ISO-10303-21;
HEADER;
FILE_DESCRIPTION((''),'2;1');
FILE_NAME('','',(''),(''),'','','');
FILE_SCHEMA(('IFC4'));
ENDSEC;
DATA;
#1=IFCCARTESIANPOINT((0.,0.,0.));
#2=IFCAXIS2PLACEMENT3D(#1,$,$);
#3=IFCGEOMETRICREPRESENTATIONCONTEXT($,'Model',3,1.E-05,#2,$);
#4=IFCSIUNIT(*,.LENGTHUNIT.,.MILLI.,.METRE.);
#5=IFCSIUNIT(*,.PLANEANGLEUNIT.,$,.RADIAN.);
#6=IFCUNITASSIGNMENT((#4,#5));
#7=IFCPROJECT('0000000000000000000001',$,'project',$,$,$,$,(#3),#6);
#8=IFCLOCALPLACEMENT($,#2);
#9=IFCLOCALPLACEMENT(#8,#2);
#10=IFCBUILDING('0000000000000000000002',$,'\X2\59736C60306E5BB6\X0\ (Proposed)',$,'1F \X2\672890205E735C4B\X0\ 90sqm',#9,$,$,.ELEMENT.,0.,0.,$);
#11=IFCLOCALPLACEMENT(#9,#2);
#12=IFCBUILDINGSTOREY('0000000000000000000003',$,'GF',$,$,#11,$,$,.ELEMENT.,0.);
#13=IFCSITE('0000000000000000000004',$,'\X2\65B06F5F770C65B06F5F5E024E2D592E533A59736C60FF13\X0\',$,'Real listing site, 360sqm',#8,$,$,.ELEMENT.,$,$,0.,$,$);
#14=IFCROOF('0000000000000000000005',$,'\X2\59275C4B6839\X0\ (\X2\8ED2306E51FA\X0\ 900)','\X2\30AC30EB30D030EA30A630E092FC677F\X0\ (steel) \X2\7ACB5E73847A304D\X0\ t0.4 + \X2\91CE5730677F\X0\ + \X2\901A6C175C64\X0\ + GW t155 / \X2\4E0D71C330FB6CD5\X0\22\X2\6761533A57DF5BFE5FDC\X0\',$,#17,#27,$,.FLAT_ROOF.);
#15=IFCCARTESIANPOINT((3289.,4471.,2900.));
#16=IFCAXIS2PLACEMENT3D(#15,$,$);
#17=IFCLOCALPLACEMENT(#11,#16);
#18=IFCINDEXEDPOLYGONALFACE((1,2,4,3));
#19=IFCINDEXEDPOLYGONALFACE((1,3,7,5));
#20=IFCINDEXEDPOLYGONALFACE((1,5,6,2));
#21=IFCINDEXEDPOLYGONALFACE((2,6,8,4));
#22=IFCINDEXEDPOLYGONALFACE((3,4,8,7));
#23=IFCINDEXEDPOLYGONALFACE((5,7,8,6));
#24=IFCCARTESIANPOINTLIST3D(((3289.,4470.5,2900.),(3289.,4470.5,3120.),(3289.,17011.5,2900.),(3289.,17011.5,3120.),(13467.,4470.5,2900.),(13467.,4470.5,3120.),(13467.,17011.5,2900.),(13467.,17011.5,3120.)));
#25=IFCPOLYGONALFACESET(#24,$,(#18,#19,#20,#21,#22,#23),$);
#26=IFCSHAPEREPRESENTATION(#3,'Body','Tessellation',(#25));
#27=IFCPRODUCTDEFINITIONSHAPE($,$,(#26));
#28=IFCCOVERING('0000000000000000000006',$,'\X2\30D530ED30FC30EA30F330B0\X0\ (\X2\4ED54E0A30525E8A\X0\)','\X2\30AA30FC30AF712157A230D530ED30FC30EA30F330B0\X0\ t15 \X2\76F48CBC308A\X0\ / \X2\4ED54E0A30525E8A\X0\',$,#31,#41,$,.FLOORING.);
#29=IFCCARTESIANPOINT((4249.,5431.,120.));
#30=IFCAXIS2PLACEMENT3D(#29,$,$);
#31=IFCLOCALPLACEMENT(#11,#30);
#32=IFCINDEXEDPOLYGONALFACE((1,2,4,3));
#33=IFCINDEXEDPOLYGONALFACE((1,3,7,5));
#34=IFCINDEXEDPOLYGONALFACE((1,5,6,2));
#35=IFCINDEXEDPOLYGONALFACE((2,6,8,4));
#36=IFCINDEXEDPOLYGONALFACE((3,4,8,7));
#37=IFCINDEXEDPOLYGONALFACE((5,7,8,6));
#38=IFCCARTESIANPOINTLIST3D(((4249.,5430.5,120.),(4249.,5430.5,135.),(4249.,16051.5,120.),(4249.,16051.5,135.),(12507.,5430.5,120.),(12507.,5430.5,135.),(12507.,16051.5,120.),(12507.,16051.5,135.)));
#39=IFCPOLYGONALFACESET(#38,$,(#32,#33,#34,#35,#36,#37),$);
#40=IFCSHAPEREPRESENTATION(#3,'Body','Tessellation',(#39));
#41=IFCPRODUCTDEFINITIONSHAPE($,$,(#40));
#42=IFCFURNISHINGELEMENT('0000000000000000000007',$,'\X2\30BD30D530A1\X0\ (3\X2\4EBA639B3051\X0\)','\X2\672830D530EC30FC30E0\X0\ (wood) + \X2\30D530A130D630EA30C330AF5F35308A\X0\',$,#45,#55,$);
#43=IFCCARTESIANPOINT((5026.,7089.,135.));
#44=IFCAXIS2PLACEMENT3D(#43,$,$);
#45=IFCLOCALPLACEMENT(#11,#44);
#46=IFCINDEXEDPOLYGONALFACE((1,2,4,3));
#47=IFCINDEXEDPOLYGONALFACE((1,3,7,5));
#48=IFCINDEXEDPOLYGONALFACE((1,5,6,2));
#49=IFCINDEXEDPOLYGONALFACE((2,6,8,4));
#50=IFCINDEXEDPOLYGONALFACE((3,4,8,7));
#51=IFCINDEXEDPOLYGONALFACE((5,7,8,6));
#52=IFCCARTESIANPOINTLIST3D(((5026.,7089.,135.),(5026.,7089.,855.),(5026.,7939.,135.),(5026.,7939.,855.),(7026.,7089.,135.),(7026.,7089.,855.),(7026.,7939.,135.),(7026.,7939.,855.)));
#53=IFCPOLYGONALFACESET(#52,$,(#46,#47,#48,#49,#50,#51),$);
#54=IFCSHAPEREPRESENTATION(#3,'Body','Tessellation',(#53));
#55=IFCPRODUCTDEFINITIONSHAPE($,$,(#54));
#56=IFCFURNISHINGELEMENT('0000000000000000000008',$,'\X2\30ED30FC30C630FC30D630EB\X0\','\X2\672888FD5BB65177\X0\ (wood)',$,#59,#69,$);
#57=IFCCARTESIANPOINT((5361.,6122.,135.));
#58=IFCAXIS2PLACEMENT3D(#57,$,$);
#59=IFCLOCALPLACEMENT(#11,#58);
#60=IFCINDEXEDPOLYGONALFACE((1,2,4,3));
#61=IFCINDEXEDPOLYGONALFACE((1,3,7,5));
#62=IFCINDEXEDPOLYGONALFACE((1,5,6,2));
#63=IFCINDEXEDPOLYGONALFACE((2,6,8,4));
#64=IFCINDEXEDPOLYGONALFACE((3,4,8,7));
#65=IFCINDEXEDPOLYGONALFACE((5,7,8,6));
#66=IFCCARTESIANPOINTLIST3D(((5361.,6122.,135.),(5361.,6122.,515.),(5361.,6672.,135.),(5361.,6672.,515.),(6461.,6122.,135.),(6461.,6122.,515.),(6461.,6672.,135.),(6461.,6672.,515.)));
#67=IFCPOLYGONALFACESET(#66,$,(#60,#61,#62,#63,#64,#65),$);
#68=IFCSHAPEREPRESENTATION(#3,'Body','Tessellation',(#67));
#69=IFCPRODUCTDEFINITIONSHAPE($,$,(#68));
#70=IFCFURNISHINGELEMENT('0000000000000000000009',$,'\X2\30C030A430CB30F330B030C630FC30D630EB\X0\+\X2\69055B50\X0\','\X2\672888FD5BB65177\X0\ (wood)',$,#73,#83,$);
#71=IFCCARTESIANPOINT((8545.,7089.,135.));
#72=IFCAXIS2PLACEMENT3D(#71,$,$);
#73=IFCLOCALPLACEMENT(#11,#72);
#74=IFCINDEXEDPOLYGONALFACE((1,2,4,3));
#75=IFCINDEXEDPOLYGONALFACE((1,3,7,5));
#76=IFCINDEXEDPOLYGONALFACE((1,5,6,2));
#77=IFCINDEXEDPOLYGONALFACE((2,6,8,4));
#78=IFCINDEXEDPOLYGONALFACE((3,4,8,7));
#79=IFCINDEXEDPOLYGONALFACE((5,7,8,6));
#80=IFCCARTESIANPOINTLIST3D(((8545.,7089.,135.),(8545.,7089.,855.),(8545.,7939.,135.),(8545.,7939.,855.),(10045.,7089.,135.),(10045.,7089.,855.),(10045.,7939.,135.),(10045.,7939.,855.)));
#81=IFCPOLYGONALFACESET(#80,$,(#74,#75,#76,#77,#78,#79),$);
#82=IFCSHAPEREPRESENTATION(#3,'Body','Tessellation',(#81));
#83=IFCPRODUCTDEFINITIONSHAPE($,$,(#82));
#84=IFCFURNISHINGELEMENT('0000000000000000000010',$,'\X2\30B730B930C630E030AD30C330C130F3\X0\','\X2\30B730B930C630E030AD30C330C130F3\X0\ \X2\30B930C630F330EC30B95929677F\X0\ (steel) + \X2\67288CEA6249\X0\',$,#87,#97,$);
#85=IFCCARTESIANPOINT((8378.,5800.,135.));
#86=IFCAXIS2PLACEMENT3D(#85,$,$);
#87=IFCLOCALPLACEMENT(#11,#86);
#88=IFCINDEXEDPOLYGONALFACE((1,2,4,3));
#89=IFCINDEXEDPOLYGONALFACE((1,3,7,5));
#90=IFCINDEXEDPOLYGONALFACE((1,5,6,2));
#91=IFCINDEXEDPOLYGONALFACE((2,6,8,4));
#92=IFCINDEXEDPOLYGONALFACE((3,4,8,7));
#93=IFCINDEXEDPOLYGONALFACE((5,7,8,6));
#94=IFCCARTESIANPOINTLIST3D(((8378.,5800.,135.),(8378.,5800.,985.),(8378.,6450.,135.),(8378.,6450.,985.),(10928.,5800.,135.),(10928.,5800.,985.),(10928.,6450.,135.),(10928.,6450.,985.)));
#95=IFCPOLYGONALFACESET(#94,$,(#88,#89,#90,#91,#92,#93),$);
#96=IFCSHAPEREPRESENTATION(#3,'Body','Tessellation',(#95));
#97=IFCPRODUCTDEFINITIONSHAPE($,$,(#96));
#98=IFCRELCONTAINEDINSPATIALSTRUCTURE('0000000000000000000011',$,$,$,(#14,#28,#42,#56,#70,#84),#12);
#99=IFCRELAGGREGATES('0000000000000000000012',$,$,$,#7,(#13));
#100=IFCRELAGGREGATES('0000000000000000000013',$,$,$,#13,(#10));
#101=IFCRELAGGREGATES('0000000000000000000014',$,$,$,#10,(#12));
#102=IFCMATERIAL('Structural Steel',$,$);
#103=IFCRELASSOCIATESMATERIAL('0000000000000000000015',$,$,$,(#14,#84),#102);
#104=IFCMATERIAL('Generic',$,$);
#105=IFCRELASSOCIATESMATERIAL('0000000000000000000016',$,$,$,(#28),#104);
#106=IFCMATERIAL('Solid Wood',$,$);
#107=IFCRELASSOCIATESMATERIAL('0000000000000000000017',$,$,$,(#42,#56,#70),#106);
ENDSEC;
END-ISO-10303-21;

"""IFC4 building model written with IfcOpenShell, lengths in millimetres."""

from ifc_helpers import new_model, si_unit, frame, frame_2d, origin, place, context, project, spatial, rectangle, extrude, material, element, save


model = new_model("IFC4")

# Units and contexts
model_context = context("Model", 3, precision=1e-05, world=origin())
ifc_project = project(units=[si_unit("LENGTHUNIT", "METRE", prefix="MILLI"), si_unit("PLANEANGLEUNIT", "RADIAN")], contexts=[model_context])

# Site, building, storey
site_placement = place(None, origin())
site = spatial("IfcSite", under=ifc_project, at=site_placement, Name="新潟県新潟市中央区女池３", ObjectType="Real listing site, 360sqm", CompositionType="ELEMENT", RefElevation=0.0)
building_placement = place(site_placement, origin())
building = spatial("IfcBuilding", under=site, at=building_placement, Name="女池の家 (Proposed)", ObjectType="1F 木造平屋 90sqm", CompositionType="ELEMENT", ElevationOfRefHeight=0.0, ElevationOfTerrain=0.0)
storey_placement = place(building_placement, origin())
storey = spatial("IfcBuildingStorey", under=building, at=storey_placement, Name="GF", CompositionType="ELEMENT", Elevation=0.0)

# Shared definitions
ifc_material_1 = material(Name="Solid Wood")

# Roof
ifc_material_2 = material(Name="Structural Steel")
roof_placement = place(storey_placement, frame((3289.0, 4471.0, 2900.0)))
element("IfcRoof", 1, at=roof_placement, inside=storey, material=ifc_material_2, Name="大屋根 (軒の出 900)", Description="ガルバリウム鋼板 (steel) 立平葺き t0.4 + 野地板 + 通気層 + GW t155 / 不燃・法22条区域対応", PredefinedType="FLAT_ROOF", context=model_context, shape_type="SweptSolid", body=[
    extrude(rectangle(XDim=10178.0, YDim=12541.0, at=frame_2d((5089.0, 6270.0))), frame((3289.0, 4471.0, 2900.0)), (0.0, 0.0, 1.0), 220.0),
])

# Covering
ifc_material_3 = material(Name="Generic")
covering_placement = place(storey_placement, frame((4249.0, 5431.0, 120.0)))
element("IfcCovering", 2, at=covering_placement, inside=storey, material=ifc_material_3, Name="フローリング (仕上げ床)", Description="オーク無垢フローリング t15 直貼り / 仕上げ床", PredefinedType="FLOORING", context=model_context, shape_type="SweptSolid", body=[
    extrude(rectangle(XDim=8258.0, YDim=10621.0, at=frame_2d((4129.0, 5310.0))), frame((4249.0, 5431.0, 120.0)), (0.0, 0.0, 1.0), 15.0),
])

# Furnishing elements
furnishing_1_placement = place(storey_placement, frame((5026.0, 7089.0, 135.0)))
element("IfcFurnishingElement", 3, at=furnishing_1_placement, inside=storey, material=ifc_material_1, Name="ソファ (3人掛け)", Description="木フレーム (wood) + ファブリック張り", context=model_context, shape_type="SweptSolid", body=[
    extrude(rectangle(XDim=2000.0, YDim=850.0, at=frame_2d((1000.0, 425.0))), frame((5026.0, 7089.0, 135.0)), (0.0, 0.0, 1.0), 720.0),
])
furnishing_2_placement = place(storey_placement, frame((5361.0, 6122.0, 135.0)))
element("IfcFurnishingElement", 4, at=furnishing_2_placement, inside=storey, material=ifc_material_1, Name="ローテーブル", Description="木製家具 (wood)", context=model_context, shape_type="SweptSolid", body=[
    extrude(rectangle(XDim=1100.0, YDim=550.0, at=frame_2d((550.0, 275.0))), frame((5361.0, 6122.0, 135.0)), (0.0, 0.0, 1.0), 380.0),
])
furnishing_3_placement = place(storey_placement, frame((8545.0, 7089.0, 135.0)))
element("IfcFurnishingElement", 5, at=furnishing_3_placement, inside=storey, material=ifc_material_1, Name="ダイニングテーブル+椅子", Description="木製家具 (wood)", context=model_context, shape_type="SweptSolid", body=[
    extrude(rectangle(XDim=1500.0, YDim=850.0, at=frame_2d((750.0, 425.0))), frame((8545.0, 7089.0, 135.0)), (0.0, 0.0, 1.0), 720.0),
])
furnishing_4_placement = place(storey_placement, frame((8378.0, 5800.0, 135.0)))
element("IfcFurnishingElement", 6, at=furnishing_4_placement, inside=storey, material=ifc_material_2, Name="システムキッチン", Description="システムキッチン ステンレス天板 (steel) + 木質扉", context=model_context, shape_type="SweptSolid", body=[
    extrude(rectangle(XDim=2550.0, YDim=650.0, at=frame_2d((1275.0, 325.0))), frame((8378.0, 5800.0, 135.0)), (0.0, 0.0, 1.0), 850.0),
])

save(model, "model.ifc")
